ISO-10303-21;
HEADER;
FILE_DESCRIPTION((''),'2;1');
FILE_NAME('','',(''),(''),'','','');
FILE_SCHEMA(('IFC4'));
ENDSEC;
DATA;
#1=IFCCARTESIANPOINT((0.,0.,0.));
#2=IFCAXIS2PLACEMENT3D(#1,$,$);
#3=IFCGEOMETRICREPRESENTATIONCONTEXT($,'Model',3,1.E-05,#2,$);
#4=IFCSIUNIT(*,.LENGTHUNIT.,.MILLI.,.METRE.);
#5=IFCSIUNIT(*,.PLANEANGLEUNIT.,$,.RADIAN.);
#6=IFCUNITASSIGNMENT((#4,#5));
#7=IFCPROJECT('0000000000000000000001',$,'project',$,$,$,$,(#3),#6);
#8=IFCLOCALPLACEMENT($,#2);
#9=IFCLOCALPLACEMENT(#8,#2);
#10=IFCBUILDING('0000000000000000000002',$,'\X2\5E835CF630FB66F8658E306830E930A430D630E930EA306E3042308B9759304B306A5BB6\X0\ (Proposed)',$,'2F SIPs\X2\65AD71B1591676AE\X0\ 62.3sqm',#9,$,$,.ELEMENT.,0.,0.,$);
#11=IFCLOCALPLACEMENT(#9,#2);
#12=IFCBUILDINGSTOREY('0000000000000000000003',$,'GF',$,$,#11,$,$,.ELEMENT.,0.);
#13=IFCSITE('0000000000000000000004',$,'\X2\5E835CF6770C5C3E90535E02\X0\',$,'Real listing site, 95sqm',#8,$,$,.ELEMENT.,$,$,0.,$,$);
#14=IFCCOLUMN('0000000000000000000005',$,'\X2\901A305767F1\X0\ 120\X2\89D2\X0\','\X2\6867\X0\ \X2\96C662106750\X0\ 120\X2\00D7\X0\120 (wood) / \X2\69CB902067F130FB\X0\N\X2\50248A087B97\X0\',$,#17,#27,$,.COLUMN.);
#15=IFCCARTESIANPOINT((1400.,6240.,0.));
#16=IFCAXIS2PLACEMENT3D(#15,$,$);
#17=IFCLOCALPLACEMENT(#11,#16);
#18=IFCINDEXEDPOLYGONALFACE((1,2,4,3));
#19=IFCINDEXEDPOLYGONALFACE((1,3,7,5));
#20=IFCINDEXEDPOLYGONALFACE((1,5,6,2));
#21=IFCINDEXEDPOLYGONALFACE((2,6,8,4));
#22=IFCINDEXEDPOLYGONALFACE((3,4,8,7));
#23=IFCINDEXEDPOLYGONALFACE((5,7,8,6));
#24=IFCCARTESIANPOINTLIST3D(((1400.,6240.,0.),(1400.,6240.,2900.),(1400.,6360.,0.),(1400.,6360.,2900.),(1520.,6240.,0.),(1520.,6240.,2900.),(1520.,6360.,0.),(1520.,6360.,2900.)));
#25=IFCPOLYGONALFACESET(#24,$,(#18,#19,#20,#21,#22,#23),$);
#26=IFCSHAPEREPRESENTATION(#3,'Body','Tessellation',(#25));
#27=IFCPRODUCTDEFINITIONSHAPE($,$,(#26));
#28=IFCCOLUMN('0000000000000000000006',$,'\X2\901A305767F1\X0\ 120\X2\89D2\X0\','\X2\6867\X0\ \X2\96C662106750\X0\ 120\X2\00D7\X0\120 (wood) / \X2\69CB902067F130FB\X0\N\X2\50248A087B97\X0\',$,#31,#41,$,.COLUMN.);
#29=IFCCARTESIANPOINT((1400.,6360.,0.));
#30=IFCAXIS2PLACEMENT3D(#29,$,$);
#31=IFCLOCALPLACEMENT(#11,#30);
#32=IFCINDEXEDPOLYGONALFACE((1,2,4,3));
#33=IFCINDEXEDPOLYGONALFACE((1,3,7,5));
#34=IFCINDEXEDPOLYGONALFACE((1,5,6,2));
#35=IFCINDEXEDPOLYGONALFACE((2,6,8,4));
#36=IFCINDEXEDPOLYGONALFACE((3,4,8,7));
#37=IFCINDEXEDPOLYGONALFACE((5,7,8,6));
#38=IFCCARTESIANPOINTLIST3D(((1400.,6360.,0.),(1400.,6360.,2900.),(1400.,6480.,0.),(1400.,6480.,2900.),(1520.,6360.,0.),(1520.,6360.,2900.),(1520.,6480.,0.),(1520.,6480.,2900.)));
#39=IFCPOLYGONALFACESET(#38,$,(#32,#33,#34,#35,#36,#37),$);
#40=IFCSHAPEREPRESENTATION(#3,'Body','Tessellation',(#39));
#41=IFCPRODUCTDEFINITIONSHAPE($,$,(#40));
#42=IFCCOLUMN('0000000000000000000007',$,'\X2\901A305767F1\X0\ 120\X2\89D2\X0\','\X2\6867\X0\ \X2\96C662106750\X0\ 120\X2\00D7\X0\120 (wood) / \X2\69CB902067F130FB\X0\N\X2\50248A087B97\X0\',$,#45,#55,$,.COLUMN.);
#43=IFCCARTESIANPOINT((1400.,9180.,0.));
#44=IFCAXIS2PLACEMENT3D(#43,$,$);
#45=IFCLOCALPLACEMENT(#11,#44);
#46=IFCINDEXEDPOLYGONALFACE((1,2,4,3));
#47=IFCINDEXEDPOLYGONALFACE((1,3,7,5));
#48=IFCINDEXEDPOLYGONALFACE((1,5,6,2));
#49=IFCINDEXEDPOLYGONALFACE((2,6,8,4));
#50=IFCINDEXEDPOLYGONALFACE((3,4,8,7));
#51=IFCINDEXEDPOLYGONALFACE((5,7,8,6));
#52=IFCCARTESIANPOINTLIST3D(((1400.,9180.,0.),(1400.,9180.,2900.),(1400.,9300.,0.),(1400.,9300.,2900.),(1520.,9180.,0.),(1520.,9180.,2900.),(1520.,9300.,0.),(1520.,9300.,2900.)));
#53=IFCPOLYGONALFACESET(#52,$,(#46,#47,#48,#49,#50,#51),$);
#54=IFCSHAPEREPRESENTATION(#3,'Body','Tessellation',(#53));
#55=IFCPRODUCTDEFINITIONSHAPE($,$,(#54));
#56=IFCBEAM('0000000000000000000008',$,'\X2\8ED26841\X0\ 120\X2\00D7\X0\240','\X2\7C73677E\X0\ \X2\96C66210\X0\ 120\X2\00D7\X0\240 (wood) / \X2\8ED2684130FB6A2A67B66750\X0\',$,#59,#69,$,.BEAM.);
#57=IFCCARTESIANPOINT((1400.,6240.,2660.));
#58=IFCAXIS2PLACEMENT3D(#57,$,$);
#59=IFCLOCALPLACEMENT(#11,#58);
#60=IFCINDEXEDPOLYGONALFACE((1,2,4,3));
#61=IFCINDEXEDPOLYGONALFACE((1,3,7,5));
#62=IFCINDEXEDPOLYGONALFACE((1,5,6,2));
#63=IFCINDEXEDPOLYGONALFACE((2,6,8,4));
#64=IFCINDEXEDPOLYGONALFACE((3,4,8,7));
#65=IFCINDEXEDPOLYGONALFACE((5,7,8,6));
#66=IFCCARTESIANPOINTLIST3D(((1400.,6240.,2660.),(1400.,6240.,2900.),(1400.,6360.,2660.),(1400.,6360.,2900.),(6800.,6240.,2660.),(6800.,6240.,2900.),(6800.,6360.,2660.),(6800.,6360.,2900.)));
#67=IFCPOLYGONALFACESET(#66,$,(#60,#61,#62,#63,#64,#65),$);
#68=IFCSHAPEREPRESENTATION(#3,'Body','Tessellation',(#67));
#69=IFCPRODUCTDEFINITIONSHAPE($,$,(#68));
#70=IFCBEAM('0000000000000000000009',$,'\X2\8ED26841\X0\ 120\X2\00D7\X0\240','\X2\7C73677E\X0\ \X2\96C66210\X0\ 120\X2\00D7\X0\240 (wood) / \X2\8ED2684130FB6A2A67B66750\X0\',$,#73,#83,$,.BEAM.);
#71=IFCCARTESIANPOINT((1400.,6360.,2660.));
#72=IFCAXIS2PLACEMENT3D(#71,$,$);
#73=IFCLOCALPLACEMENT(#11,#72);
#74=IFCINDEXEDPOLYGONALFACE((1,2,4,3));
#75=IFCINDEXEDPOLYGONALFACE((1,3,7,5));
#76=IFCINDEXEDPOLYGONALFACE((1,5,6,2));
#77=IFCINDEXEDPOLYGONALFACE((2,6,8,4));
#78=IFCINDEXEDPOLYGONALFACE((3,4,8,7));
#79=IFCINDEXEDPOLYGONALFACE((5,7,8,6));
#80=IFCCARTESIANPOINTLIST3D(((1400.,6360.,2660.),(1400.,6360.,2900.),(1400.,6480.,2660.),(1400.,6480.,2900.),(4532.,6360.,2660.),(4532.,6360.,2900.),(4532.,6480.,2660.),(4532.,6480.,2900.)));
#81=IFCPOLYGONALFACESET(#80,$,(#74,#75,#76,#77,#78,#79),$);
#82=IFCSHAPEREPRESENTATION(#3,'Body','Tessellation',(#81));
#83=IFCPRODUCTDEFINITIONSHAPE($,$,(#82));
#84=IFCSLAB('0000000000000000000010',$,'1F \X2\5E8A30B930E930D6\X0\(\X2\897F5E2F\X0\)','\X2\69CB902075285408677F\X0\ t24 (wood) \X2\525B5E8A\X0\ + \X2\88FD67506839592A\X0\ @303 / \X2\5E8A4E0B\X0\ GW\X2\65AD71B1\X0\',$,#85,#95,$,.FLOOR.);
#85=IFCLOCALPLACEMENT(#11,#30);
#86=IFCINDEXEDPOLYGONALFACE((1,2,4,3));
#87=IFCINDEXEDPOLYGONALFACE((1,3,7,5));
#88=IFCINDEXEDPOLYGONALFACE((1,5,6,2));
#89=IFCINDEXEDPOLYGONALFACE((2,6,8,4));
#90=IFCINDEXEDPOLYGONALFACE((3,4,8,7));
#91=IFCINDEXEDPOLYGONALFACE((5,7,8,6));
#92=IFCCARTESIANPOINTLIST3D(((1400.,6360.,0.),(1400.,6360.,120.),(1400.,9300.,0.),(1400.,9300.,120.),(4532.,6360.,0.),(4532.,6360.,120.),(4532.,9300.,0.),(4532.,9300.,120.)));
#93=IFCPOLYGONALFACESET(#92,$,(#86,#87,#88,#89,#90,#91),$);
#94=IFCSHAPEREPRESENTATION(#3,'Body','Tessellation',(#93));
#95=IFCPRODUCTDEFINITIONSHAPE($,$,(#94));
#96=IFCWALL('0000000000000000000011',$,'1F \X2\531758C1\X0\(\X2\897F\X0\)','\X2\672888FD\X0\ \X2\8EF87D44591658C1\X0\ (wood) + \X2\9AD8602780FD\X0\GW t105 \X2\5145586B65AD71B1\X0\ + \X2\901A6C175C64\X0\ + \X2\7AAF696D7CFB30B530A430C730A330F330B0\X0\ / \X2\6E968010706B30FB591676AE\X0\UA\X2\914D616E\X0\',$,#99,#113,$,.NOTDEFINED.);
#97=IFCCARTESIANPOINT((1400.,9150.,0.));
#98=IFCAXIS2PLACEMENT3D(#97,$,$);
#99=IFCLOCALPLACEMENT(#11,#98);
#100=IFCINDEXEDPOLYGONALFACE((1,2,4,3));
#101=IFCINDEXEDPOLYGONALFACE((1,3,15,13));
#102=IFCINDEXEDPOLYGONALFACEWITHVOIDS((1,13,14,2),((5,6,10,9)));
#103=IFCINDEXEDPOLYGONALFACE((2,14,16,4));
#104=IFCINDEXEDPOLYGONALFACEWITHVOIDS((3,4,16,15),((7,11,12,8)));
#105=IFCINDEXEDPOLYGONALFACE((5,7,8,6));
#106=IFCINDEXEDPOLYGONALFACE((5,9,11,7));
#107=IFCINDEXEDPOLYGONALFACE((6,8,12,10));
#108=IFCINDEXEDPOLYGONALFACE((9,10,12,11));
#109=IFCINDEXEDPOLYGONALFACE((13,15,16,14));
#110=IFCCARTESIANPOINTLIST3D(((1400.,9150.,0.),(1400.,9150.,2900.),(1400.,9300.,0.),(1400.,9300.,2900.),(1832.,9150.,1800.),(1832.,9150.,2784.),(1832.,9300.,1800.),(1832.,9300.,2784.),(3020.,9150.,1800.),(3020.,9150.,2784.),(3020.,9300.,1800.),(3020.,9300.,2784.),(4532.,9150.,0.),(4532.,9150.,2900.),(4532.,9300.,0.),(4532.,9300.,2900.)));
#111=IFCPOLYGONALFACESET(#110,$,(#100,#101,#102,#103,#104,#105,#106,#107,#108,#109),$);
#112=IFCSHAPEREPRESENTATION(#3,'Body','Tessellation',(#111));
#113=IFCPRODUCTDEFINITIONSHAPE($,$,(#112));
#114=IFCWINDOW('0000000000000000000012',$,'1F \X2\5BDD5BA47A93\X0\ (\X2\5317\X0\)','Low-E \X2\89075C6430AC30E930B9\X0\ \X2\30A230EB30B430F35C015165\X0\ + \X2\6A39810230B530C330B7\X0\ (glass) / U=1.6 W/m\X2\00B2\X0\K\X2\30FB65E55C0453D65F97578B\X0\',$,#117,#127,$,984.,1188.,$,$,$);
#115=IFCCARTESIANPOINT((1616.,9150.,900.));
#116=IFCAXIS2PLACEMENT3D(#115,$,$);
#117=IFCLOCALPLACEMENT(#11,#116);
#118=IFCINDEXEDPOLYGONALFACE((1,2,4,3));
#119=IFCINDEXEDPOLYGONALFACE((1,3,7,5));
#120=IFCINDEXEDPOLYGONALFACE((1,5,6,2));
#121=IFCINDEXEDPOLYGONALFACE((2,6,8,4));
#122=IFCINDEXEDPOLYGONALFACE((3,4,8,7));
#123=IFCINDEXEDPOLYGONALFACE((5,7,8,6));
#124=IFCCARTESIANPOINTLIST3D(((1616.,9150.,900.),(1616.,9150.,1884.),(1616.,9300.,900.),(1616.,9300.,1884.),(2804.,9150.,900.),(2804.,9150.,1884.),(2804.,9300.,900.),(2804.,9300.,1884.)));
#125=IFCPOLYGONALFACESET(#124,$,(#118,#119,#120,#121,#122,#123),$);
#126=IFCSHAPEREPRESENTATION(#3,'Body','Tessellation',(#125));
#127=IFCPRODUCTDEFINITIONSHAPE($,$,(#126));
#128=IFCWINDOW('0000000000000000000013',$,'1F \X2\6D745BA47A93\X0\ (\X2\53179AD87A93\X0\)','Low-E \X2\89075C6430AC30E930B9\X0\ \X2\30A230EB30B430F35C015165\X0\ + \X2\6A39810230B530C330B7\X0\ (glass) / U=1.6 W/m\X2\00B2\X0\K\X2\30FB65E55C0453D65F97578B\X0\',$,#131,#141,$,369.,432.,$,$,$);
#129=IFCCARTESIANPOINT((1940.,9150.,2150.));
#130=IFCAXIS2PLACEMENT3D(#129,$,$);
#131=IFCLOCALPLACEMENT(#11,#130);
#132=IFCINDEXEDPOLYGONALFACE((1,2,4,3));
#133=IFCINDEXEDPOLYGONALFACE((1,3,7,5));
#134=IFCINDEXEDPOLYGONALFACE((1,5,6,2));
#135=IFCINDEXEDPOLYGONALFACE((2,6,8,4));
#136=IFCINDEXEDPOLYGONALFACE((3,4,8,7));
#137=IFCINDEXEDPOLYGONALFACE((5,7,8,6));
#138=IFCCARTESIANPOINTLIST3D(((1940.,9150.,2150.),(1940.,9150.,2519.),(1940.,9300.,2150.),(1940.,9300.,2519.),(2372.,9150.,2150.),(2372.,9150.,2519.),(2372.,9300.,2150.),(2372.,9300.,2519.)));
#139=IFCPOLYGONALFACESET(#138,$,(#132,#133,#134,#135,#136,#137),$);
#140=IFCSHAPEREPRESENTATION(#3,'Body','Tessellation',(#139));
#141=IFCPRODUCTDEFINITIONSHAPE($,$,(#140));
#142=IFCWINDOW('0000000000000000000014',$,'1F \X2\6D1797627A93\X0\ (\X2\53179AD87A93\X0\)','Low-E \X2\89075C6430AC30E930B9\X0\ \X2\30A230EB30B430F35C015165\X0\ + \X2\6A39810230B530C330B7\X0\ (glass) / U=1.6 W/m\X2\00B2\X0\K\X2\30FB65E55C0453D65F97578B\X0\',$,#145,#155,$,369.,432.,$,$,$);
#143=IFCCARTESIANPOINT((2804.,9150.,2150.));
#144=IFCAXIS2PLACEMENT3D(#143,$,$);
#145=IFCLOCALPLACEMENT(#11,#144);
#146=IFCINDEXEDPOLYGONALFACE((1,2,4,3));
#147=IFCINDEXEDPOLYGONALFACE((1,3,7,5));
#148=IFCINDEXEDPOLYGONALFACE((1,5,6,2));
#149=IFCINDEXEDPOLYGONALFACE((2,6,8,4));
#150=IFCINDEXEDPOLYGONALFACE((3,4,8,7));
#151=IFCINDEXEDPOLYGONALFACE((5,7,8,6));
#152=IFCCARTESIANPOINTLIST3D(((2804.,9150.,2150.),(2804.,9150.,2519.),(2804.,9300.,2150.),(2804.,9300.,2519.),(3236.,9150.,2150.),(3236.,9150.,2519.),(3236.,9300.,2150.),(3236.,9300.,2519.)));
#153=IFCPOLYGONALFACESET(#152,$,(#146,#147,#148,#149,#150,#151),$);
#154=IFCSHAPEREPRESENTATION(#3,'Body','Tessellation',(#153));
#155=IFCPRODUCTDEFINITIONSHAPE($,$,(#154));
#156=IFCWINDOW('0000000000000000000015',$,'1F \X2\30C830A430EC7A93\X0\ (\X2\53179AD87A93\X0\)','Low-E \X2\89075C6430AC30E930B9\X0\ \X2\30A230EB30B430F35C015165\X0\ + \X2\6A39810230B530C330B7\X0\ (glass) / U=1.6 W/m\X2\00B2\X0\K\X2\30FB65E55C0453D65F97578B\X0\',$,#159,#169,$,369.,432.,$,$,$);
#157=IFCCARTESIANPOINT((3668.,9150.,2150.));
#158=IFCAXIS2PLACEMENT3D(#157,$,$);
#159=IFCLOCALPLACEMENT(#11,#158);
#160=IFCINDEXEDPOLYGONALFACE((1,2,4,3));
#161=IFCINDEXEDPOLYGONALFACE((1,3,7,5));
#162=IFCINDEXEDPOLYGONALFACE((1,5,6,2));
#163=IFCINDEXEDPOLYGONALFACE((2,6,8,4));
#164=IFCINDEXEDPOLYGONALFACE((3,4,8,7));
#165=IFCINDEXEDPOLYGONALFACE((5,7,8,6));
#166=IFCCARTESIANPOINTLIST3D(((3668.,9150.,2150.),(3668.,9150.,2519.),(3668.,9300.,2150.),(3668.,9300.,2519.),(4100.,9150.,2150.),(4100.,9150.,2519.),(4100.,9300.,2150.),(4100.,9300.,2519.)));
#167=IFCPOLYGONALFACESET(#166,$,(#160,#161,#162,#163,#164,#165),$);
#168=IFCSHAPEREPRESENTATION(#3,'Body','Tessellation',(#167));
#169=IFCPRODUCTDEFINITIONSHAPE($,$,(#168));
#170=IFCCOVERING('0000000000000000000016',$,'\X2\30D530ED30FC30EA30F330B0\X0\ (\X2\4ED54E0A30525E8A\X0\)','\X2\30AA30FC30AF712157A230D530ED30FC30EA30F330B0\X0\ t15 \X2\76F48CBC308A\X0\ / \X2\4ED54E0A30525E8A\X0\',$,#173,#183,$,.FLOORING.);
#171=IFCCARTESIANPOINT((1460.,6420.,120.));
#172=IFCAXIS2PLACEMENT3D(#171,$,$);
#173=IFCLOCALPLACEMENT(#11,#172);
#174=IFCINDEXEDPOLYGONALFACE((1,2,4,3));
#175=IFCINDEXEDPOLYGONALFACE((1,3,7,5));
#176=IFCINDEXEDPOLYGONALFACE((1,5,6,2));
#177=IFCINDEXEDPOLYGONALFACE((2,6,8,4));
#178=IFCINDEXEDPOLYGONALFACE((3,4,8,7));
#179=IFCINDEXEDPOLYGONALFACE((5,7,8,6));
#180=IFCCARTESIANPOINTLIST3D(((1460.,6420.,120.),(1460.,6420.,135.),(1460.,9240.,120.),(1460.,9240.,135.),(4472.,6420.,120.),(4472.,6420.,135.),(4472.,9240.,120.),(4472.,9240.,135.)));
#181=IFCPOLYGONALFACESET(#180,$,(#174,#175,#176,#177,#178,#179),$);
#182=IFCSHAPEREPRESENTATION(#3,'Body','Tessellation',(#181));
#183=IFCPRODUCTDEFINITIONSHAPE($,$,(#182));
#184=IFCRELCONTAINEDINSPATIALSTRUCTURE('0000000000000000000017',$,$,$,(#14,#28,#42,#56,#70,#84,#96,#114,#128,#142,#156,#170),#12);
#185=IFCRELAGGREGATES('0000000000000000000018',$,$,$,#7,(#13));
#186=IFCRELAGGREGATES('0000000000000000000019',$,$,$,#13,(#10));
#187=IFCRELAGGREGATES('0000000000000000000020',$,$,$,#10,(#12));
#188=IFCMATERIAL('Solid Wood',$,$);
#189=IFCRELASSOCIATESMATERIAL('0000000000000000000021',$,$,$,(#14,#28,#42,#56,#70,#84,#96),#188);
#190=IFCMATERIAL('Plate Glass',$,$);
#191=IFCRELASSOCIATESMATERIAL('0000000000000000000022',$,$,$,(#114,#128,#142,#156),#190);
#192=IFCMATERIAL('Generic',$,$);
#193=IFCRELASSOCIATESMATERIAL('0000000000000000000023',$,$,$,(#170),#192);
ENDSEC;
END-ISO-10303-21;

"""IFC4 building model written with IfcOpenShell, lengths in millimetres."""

from ifc_helpers import new_model, si_unit, frame, frame_2d, origin, place, context, project, spatial, rectangle, extrude, material, element, fill, save


model = new_model("IFC4")

# Units and contexts
model_context = context("Model", 3, precision=1e-05, world=origin())
ifc_project = project(units=[si_unit("LENGTHUNIT", "METRE", prefix="MILLI"), si_unit("PLANEANGLEUNIT", "RADIAN")], contexts=[model_context])

# Site, building, storey
site_placement = place(None, origin())
site = spatial("IfcSite", under=ifc_project, at=site_placement, Name="広島県尾道市", ObjectType="Real listing site, 95sqm", CompositionType="ELEMENT", RefElevation=0.0)
building_placement = place(site_placement, origin())
building = spatial("IfcBuilding", under=site, at=building_placement, Name="広島・書斎とライブラリのある静かな家 (Proposed)", ObjectType="2F SIPs断熱外皮 62.3sqm", CompositionType="ELEMENT", ElevationOfRefHeight=0.0, ElevationOfTerrain=0.0)
storey_placement = place(building_placement, origin())
storey = spatial("IfcBuildingStorey", under=building, at=storey_placement, Name="GF", CompositionType="ELEMENT", Elevation=0.0)

# Columns
ifc_material_1 = material(Name="Solid Wood")
column_1_placement = place(storey_placement, frame((1400.0, 6240.0, 0.0)))
element("IfcColumn", 1, at=column_1_placement, inside=storey, material=ifc_material_1, Name="通し柱 120角", Description="桧 集成材 120×120 (wood) / 構造柱・N値計算", PredefinedType="COLUMN", context=model_context, shape_type="SweptSolid", body=[
    extrude(rectangle(XDim=120.0, YDim=120.0, at=frame_2d((60.0, 60.0))), frame((1400.0, 6240.0, 0.0)), (0.0, 0.0, 1.0), 2900.0),
])
column_2_placement = place(storey_placement, frame((1400.0, 6360.0, 0.0)))
element("IfcColumn", 2, at=column_2_placement, inside=storey, material=ifc_material_1, Name="通し柱 120角", Description="桧 集成材 120×120 (wood) / 構造柱・N値計算", PredefinedType="COLUMN", context=model_context, shape_type="SweptSolid", body=[
    extrude(rectangle(XDim=120.0, YDim=120.0, at=frame_2d((60.0, 60.0))), frame((1400.0, 6360.0, 0.0)), (0.0, 0.0, 1.0), 2900.0),
])
column_3_placement = place(storey_placement, frame((1400.0, 9180.0, 0.0)))
element("IfcColumn", 3, at=column_3_placement, inside=storey, material=ifc_material_1, Name="通し柱 120角", Description="桧 集成材 120×120 (wood) / 構造柱・N値計算", PredefinedType="COLUMN", context=model_context, shape_type="SweptSolid", body=[
    extrude(rectangle(XDim=120.0, YDim=120.0, at=frame_2d((60.0, 60.0))), frame((1400.0, 9180.0, 0.0)), (0.0, 0.0, 1.0), 2900.0),
])

# Beams
beam_1_placement = place(storey_placement, frame((1400.0, 6240.0, 2660.0)))
element("IfcBeam", 4, at=beam_1_placement, inside=storey, material=ifc_material_1, Name="軒桁 120×240", Description="米松 集成 120×240 (wood) / 軒桁・横架材", PredefinedType="BEAM", context=model_context, shape_type="SweptSolid", body=[
    extrude(rectangle(XDim=5400.0, YDim=120.0, at=frame_2d((2700.0, 60.0))), frame((1400.0, 6240.0, 2660.0)), (0.0, 0.0, 1.0), 240.0),
])
beam_2_placement = place(storey_placement, frame((1400.0, 6360.0, 2660.0)))
element("IfcBeam", 5, at=beam_2_placement, inside=storey, material=ifc_material_1, Name="軒桁 120×240", Description="米松 集成 120×240 (wood) / 軒桁・横架材", PredefinedType="BEAM", context=model_context, shape_type="SweptSolid", body=[
    extrude(rectangle(XDim=3132.0, YDim=120.0, at=frame_2d((1566.0, 60.0))), frame((1400.0, 6360.0, 2660.0)), (0.0, 0.0, 1.0), 240.0),
])

# Slab
slab_placement = place(storey_placement, frame((1400.0, 6360.0, 0.0)))
element("IfcSlab", 6, at=slab_placement, inside=storey, material=ifc_material_1, Name="1F 床スラブ(西帯)", Description="構造用合板 t24 (wood) 剛床 + 製材根太 @303 / 床下 GW断熱", PredefinedType="FLOOR", context=model_context, shape_type="SweptSolid", body=[
    extrude(rectangle(XDim=3132.0, YDim=2940.0, at=frame_2d((1566.0, 1470.0))), frame((1400.0, 6360.0, 0.0)), (0.0, 0.0, 1.0), 120.0),
])

# Wall, openings, windows
wall_1_placement = place(storey_placement, frame((1400.0, 9150.0, 0.0)))
wall_1 = element("IfcWall", 7, at=wall_1_placement, inside=storey, material=ifc_material_1, Name="1F 北壁(西)", Description="木製 軸組外壁 (wood) + 高性能GW t105 充填断熱 + 通気層 + 窯業系サイディング / 準耐火・外皮UA配慮", PredefinedType="NOTDEFINED", context=model_context, shape_type="SweptSolid", body=[
    extrude(rectangle(XDim=3132.0, YDim=150.0, at=frame_2d((1566.0, 75.0))), frame((1400.0, 9150.0, 0.0)), (0.0, 0.0, 1.0), 2900.0),
])
opening_1_placement = place(storey_placement, frame((1616.0, 9150.0, 900.0)))
opening_1 = element("IfcOpeningElement", 8, at=opening_1_placement, cuts=wall_1, PredefinedType="NOTDEFINED", context=model_context, shape_type="SweptSolid", body=[
    extrude(rectangle(XDim=1188.0, YDim=150.0, at=frame_2d((594.0, 75.0))), frame((1616.0, 9150.0, 900.0)), (0.0, 0.0, 1.0), 984.0),
])
opening_2_placement = place(storey_placement, frame((1940.0, 9150.0, 2150.0)))
opening_2 = element("IfcOpeningElement", 9, at=opening_2_placement, cuts=wall_1, PredefinedType="NOTDEFINED", context=model_context, shape_type="SweptSolid", body=[
    extrude(rectangle(XDim=432.0, YDim=150.0, at=frame_2d((216.0, 75.0))), frame((1940.0, 9150.0, 2150.0)), (0.0, 0.0, 1.0), 369.0),
])
opening_3_placement = place(storey_placement, frame((2804.0, 9150.0, 2150.0)))
opening_3 = element("IfcOpeningElement", 10, at=opening_3_placement, cuts=wall_1, PredefinedType="NOTDEFINED", context=model_context, shape_type="SweptSolid", body=[
    extrude(rectangle(XDim=432.0, YDim=150.0, at=frame_2d((216.0, 75.0))), frame((2804.0, 9150.0, 2150.0)), (0.0, 0.0, 1.0), 369.0),
])
opening_4_placement = place(storey_placement, frame((3668.0, 9150.0, 2150.0)))
opening_4 = element("IfcOpeningElement", 11, at=opening_4_placement, cuts=wall_1, PredefinedType="NOTDEFINED", context=model_context, shape_type="SweptSolid", body=[
    extrude(rectangle(XDim=432.0, YDim=150.0, at=frame_2d((216.0, 75.0))), frame((3668.0, 9150.0, 2150.0)), (0.0, 0.0, 1.0), 369.0),
])
ifc_material_2 = material(Name="Plate Glass")
window_1_placement = place(storey_placement, frame((1616.0, 9150.0, 900.0)))
window_1 = element("IfcWindow", 12, at=window_1_placement, inside=storey, material=ifc_material_2, Name="1F 寝室窓 (北)", Description="Low-E 複層ガラス アルゴン封入 + 樹脂サッシ (glass) / U=1.6 W/m²K・日射取得型", OverallHeight=984.0, OverallWidth=1188.0, context=model_context, shape_type="SweptSolid", body=[
    extrude(rectangle(XDim=1188.0, YDim=150.0, at=frame_2d((594.0, 75.0))), frame((1616.0, 9150.0, 900.0)), (0.0, 0.0, 1.0), 984.0),
])
fill(opening_1, window_1)
window_2_placement = place(storey_placement, frame((1940.0, 9150.0, 2150.0)))
window_2 = element("IfcWindow", 13, at=window_2_placement, inside=storey, material=ifc_material_2, Name="1F 浴室窓 (北高窓)", Description="Low-E 複層ガラス アルゴン封入 + 樹脂サッシ (glass) / U=1.6 W/m²K・日射取得型", OverallHeight=369.0, OverallWidth=432.0, context=model_context, shape_type="SweptSolid", body=[
    extrude(rectangle(XDim=432.0, YDim=150.0, at=frame_2d((216.0, 75.0))), frame((1940.0, 9150.0, 2150.0)), (0.0, 0.0, 1.0), 369.0),
])
fill(opening_2, window_2)
window_3_placement = place(storey_placement, frame((2804.0, 9150.0, 2150.0)))
window_3 = element("IfcWindow", 14, at=window_3_placement, inside=storey, material=ifc_material_2, Name="1F 洗面窓 (北高窓)", Description="Low-E 複層ガラス アルゴン封入 + 樹脂サッシ (glass) / U=1.6 W/m²K・日射取得型", OverallHeight=369.0, OverallWidth=432.0, context=model_context, shape_type="SweptSolid", body=[
    extrude(rectangle(XDim=432.0, YDim=150.0, at=frame_2d((216.0, 75.0))), frame((2804.0, 9150.0, 2150.0)), (0.0, 0.0, 1.0), 369.0),
])
fill(opening_3, window_3)
window_4_placement = place(storey_placement, frame((3668.0, 9150.0, 2150.0)))
window_4 = element("IfcWindow", 15, at=window_4_placement, inside=storey, material=ifc_material_2, Name="1F トイレ窓 (北高窓)", Description="Low-E 複層ガラス アルゴン封入 + 樹脂サッシ (glass) / U=1.6 W/m²K・日射取得型", OverallHeight=369.0, OverallWidth=432.0, context=model_context, shape_type="SweptSolid", body=[
    extrude(rectangle(XDim=432.0, YDim=150.0, at=frame_2d((216.0, 75.0))), frame((3668.0, 9150.0, 2150.0)), (0.0, 0.0, 1.0), 369.0),
])
fill(opening_4, window_4)

# Covering
ifc_material_3 = material(Name="Generic")
covering_placement = place(storey_placement, frame((1460.0, 6420.0, 120.0)))
element("IfcCovering", 16, at=covering_placement, inside=storey, material=ifc_material_3, Name="フローリング (仕上げ床)", Description="オーク無垢フローリング t15 直貼り / 仕上げ床", PredefinedType="FLOORING", context=model_context, shape_type="SweptSolid", body=[
    extrude(rectangle(XDim=3012.0, YDim=2820.0, at=frame_2d((1506.0, 1410.0))), frame((1460.0, 6420.0, 120.0)), (0.0, 0.0, 1.0), 15.0),
])

save(model, "model.ifc")
